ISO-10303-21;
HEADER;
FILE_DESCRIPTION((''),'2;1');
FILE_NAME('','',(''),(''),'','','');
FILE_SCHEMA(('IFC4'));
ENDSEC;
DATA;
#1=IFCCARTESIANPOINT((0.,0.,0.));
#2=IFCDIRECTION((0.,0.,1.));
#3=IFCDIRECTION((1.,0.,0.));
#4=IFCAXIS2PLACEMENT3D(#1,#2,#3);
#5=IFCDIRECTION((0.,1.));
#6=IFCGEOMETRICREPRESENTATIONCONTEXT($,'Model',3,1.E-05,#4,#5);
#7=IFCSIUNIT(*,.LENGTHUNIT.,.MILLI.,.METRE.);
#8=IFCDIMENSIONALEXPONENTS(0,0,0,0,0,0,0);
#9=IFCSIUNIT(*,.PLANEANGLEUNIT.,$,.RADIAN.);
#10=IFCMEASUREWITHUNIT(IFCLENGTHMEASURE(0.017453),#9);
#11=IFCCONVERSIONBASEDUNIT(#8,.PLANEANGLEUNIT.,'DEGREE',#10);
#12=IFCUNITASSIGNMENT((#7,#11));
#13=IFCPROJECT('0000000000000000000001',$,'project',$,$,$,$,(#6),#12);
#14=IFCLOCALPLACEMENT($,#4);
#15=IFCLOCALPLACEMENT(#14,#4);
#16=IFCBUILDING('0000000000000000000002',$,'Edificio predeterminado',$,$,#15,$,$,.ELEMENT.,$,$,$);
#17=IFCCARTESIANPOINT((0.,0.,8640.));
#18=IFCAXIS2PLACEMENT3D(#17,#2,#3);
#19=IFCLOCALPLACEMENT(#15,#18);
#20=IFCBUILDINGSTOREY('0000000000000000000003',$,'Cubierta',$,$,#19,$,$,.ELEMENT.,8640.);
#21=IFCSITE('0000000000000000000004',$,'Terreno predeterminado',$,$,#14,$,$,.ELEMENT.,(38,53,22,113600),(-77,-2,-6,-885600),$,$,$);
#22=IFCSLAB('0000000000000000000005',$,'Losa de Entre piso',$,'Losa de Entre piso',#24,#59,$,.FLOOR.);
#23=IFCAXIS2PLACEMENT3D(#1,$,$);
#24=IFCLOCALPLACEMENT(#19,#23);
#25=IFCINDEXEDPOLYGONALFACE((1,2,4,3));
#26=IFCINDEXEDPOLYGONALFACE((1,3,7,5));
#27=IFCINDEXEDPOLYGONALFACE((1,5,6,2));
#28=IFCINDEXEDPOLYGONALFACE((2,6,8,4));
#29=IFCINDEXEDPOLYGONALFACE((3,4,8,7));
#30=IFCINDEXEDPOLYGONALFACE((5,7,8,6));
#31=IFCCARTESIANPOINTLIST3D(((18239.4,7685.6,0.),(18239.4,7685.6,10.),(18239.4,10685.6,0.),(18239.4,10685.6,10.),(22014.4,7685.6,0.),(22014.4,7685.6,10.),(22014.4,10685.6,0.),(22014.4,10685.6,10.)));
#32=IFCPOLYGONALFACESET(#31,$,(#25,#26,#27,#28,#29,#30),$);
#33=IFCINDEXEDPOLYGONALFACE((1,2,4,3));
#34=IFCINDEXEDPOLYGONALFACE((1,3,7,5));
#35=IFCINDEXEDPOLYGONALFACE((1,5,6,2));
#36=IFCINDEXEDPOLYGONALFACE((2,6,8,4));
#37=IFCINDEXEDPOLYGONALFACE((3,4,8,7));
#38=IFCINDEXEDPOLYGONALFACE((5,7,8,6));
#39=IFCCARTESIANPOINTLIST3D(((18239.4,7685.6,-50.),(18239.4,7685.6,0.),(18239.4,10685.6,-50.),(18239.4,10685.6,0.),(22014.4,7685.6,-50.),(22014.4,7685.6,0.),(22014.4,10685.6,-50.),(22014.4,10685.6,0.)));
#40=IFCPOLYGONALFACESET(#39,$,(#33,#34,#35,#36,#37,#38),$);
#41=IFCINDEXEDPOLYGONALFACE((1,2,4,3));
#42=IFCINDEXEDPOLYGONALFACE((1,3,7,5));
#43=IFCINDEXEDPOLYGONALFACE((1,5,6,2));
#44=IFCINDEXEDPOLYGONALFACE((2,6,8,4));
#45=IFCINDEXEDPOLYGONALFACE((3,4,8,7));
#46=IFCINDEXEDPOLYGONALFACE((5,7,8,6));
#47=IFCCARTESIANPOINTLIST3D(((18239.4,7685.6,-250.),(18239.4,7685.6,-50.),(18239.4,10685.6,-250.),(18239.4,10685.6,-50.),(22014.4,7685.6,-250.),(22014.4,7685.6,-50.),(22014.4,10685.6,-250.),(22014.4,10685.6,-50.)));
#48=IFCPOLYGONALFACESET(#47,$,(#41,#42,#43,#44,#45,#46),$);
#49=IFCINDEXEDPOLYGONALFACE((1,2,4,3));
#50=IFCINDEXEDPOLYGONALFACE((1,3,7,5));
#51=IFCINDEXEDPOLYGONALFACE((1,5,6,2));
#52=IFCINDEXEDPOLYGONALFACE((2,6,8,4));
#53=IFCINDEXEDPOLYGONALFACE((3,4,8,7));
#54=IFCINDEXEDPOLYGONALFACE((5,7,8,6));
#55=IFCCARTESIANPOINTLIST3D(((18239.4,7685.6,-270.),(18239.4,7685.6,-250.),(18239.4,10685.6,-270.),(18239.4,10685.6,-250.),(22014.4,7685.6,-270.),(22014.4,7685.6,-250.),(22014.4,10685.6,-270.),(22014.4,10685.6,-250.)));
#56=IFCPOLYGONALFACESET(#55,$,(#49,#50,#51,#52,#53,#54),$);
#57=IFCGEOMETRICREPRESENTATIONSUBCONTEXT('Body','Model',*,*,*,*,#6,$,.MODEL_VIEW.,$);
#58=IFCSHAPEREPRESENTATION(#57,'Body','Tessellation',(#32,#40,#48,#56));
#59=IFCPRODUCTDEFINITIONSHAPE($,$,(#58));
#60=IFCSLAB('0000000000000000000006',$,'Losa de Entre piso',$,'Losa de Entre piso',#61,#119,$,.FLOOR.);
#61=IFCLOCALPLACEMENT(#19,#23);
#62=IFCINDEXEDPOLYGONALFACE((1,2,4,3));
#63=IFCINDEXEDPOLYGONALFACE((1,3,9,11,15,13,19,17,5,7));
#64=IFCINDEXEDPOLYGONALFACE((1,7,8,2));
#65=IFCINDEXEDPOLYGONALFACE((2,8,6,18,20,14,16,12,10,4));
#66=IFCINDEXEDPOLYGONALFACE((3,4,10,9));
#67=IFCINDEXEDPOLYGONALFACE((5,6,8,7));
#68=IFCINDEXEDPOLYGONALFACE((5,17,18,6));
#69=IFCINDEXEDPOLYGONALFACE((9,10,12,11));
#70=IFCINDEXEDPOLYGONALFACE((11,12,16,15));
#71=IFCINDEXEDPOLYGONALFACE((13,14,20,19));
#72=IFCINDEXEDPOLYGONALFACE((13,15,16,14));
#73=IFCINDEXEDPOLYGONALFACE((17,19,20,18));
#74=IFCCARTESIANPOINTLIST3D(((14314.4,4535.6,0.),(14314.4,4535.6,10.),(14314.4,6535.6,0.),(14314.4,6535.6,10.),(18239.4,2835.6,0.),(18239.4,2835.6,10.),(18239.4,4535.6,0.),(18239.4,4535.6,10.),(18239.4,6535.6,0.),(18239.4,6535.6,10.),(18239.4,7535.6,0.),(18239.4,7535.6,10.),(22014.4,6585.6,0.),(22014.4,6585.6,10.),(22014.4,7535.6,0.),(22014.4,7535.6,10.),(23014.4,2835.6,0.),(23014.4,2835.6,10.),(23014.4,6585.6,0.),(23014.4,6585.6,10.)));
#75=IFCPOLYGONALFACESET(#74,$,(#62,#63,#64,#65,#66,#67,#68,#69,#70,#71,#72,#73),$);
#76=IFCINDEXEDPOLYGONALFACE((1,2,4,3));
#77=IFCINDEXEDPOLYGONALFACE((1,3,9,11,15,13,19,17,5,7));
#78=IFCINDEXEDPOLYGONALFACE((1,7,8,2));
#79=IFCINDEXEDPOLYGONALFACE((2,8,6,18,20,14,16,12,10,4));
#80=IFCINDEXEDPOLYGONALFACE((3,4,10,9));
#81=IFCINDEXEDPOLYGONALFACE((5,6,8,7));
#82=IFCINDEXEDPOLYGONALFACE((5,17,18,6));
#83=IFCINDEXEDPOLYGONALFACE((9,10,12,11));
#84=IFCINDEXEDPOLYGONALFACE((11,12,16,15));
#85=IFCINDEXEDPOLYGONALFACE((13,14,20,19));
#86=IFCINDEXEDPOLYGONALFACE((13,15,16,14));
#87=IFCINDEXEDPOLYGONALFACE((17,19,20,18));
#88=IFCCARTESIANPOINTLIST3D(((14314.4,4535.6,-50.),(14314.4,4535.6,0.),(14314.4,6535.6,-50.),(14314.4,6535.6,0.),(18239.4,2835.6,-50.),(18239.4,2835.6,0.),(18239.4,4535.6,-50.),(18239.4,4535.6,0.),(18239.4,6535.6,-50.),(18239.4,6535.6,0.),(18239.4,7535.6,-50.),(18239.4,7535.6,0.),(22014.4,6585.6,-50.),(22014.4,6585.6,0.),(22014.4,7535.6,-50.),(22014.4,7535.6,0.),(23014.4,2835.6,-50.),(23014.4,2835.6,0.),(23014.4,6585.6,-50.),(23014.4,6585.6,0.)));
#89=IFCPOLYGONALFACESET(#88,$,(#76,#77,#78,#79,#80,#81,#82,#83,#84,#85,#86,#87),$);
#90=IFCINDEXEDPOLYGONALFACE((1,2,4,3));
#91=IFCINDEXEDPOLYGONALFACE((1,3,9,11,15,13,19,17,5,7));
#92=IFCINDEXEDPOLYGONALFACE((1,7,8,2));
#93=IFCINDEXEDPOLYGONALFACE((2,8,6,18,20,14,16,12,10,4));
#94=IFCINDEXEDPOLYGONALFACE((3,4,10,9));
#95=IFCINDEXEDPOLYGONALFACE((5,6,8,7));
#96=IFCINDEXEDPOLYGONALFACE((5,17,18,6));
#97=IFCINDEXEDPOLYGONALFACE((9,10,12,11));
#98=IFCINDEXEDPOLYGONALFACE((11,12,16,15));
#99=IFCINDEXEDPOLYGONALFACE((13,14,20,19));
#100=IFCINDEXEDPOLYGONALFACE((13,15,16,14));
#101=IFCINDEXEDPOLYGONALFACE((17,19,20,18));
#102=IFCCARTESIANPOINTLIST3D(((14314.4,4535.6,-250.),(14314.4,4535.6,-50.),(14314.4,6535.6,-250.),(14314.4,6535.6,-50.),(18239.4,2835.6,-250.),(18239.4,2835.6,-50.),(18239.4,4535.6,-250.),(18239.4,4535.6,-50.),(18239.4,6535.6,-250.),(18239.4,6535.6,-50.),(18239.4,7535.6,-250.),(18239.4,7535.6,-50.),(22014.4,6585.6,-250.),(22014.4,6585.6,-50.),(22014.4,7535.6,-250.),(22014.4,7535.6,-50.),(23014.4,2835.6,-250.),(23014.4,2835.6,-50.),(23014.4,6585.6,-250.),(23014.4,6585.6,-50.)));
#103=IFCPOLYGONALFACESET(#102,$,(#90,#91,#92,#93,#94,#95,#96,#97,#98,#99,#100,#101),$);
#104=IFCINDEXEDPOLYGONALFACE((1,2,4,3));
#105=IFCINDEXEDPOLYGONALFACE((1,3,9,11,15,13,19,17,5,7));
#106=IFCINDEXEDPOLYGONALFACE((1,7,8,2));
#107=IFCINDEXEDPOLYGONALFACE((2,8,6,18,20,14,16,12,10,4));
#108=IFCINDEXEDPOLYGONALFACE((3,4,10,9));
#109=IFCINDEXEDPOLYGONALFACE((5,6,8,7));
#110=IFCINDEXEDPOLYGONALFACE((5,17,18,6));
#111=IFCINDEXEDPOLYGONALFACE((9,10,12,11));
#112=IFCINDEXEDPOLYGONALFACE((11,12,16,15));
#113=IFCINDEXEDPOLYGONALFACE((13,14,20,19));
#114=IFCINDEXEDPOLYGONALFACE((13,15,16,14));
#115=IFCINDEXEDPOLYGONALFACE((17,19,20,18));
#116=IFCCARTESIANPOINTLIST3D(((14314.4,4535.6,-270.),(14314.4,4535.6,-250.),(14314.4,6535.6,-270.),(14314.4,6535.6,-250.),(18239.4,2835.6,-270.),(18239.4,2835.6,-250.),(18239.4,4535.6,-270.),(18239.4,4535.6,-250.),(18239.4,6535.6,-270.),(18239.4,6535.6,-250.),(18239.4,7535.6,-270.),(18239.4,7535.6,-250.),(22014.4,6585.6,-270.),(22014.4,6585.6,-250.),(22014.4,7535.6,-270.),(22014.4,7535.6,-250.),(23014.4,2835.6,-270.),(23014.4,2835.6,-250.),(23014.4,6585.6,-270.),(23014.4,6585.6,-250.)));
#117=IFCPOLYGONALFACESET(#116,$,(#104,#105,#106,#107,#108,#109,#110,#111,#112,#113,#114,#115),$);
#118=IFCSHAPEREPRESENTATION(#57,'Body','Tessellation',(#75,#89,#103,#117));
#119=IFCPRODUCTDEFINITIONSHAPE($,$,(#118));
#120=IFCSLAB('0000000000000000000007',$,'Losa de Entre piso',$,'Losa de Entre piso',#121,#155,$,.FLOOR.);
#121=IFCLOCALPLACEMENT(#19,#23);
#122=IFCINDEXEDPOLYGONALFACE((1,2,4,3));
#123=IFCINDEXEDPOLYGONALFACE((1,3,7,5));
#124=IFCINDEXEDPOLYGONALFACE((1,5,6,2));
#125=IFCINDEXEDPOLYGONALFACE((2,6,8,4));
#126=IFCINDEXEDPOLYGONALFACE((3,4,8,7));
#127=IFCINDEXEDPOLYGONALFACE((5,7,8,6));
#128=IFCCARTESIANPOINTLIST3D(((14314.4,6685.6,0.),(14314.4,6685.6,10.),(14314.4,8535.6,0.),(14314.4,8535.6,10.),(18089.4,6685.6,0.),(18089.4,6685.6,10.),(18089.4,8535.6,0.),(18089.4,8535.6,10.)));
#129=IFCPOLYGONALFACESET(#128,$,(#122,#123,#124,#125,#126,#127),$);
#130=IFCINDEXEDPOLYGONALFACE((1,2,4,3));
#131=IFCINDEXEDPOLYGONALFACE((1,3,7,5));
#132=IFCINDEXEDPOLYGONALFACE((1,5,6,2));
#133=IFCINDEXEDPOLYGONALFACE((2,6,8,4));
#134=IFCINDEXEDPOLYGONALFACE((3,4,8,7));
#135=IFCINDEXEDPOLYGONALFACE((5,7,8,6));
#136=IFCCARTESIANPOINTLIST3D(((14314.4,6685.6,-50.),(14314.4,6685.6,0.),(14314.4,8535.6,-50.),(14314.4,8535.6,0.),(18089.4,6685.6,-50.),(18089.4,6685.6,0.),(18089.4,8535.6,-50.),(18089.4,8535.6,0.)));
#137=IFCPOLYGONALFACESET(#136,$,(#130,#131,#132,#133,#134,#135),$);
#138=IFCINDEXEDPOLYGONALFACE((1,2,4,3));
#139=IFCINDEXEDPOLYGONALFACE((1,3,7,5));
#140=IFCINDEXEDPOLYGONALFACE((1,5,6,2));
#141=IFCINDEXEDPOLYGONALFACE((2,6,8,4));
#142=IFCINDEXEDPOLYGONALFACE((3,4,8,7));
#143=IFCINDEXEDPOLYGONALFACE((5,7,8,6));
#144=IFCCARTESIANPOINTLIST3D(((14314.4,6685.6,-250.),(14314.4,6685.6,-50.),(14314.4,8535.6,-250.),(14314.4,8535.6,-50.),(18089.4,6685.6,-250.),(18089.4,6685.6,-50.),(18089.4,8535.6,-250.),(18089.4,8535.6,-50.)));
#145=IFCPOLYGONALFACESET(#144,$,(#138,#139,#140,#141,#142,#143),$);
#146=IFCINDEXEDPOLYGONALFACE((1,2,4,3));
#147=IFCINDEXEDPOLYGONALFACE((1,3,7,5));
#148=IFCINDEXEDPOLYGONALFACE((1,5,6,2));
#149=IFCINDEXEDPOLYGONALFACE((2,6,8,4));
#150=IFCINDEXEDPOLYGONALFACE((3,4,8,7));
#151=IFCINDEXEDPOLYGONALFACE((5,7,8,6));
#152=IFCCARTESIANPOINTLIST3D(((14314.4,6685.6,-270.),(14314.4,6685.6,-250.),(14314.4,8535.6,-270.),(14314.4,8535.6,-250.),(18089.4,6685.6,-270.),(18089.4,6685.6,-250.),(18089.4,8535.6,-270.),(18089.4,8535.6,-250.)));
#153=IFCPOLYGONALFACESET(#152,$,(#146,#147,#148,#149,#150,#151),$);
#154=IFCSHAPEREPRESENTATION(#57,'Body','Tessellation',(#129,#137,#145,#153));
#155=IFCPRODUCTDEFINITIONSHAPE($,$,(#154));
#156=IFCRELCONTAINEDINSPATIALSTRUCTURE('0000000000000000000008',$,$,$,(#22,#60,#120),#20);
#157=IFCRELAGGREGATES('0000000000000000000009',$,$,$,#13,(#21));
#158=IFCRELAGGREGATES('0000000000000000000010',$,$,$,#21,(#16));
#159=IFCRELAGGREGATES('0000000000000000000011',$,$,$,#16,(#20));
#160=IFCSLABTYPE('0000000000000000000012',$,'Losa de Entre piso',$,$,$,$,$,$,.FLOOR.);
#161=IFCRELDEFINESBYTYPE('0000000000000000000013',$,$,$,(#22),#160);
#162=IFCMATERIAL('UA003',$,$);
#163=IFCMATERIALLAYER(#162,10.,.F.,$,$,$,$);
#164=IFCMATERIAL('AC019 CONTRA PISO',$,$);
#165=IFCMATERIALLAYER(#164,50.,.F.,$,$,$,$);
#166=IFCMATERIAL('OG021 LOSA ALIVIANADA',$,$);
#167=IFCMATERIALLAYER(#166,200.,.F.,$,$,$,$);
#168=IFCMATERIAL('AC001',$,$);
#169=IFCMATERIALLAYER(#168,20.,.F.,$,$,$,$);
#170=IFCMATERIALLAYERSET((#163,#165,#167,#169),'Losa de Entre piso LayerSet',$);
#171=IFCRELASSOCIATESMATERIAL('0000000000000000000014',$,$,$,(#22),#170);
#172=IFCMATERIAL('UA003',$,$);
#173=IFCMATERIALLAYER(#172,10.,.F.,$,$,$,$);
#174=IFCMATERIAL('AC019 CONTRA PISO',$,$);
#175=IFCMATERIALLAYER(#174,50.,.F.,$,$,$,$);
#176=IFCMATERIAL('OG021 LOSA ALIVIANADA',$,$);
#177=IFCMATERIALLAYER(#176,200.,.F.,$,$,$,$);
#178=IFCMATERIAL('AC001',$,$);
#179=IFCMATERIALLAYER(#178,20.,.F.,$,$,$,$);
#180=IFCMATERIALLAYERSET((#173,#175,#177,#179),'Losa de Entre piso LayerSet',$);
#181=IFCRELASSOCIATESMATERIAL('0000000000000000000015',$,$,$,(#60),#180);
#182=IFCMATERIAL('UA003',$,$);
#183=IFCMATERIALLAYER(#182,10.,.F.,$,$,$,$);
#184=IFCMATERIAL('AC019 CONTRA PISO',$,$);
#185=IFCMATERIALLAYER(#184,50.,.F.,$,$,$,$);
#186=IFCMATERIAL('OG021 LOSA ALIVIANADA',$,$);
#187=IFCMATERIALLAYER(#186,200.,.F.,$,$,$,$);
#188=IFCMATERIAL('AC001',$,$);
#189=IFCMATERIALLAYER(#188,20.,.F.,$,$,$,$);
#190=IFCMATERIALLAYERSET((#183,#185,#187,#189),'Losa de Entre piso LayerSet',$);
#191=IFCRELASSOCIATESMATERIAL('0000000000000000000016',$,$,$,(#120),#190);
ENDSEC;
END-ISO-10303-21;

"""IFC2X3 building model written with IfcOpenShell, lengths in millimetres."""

from ifc_helpers import new_model, entity, si_unit, converted_unit, direction, frame, origin_with_axes, place, context, subcontext, project, spatial, polyline, outline, extrude, material, layer, layer_set, layer_usage, type_object, element, save


model = new_model("IFC2X3")

# Units and contexts
model_context = context("Model", 3, precision=1e-05, world=origin_with_axes(), true_north=direction((0.0, 1.0)))
body_context = subcontext(model_context, "Body", "Model", "MODEL_VIEW")
ifc_project = project(units=[si_unit("LENGTHUNIT", "METRE", prefix="MILLI"), converted_unit("PLANEANGLEUNIT", "DEGREE", entity("IfcLengthMeasure", 0.017453), si_unit("PLANEANGLEUNIT", "RADIAN"), dimensions=[0, 0, 0, 0, 0, 0, 0])], contexts=[model_context])

# Site, building, storey
site_placement = place(None, origin_with_axes())
site = spatial("IfcSite", under=ifc_project, at=site_placement, Name="Terreno predeterminado", CompositionType="ELEMENT", RefLatitude=(38, 53, 22, 113600), RefLongitude=(-77, -2, -6, -885600))
building_placement = place(site_placement, origin_with_axes())
building = spatial("IfcBuilding", under=site, at=building_placement, Name="Edificio predeterminado", CompositionType="ELEMENT")
storey_placement = place(building_placement, frame((0.0, 0.0, 8640.0), z_axis=(0.0, 0.0, 1.0), x_axis=(1.0, 0.0, 0.0)))
storey = spatial("IfcBuildingStorey", under=building, at=storey_placement, Name="Cubierta", CompositionType="ELEMENT", Elevation=8640.0)

# Slabs
ifc_material_1 = material(Name="UA003")
ifc_layer_1 = layer(ifc_material_1, 10.0, ventilated=False)
ifc_material_2 = material(Name="AC019 CONTRA PISO")
ifc_layer_2 = layer(ifc_material_2, 50.0, ventilated=False)
ifc_material_3 = material(Name="OG021 LOSA ALIVIANADA")
ifc_layer_3 = layer(ifc_material_3, 200.0, ventilated=False)
ifc_material_4 = material(Name="AC001")
ifc_layer_4 = layer(ifc_material_4, 20.0, ventilated=False)
ifc_layer_set_1 = layer_set([ifc_layer_1, ifc_layer_2, ifc_layer_3, ifc_layer_4], Name="Losa de Entre piso LayerSet")
ifc_layer_usage_1 = layer_usage(ifc_layer_set_1, "AXIS3", "NEGATIVE", 0.0)
slab_type = type_object("IfcSlabType", Name="Losa de Entre piso", PredefinedType="FLOOR")
slab_1_placement = place(storey_placement, frame((0.0, 0.0, -8640.0), z_axis=(0.0, 0.0, 1.0), x_axis=(1.0, 0.0, 0.0)))
element("IfcSlab", 1, at=slab_1_placement, inside=storey, type_object=slab_type, material=ifc_layer_usage_1, Name="Losa de Entre piso", ObjectType="Losa de Entre piso", PredefinedType="FLOOR", context=body_context, shape_type="SweptSolid", body=[
    extrude(outline(polyline([(0.0, 3000.0), (3775.0, 3000.0), (3775.0, 0.0), (0.0, 0.0), (0.0, 3000.0)])), frame((22014.4, 7685.6, 8640.0), z_axis=(0.0, 0.0, -1.0), x_axis=(-1.0, 0.0, 0.0)), (0.0, 0.0, -1.0), 10.0),
    extrude(outline(polyline([(0.0, 3000.0), (3775.0, 3000.0), (3775.0, 0.0), (0.0, 0.0), (0.0, 3000.0)])), frame((22014.4, 7685.6, 8590.0), z_axis=(0.0, 0.0, -1.0), x_axis=(-1.0, 0.0, 0.0)), (0.0, 0.0, -1.0), 50.0),
    extrude(outline(polyline([(0.0, 3000.0), (3775.0, 3000.0), (3775.0, 0.0), (0.0, 0.0), (0.0, 3000.0)])), frame((22014.4, 7685.6, 8390.0), z_axis=(0.0, 0.0, -1.0), x_axis=(-1.0, 0.0, 0.0)), (0.0, 0.0, -1.0), 200.0),
    extrude(outline(polyline([(0.0, 3000.0), (3775.0, 3000.0), (3775.0, 0.0), (0.0, 0.0), (0.0, 3000.0)])), frame((22014.4, 7685.6, 8370.0), z_axis=(0.0, 0.0, -1.0), x_axis=(-1.0, 0.0, 0.0)), (0.0, 0.0, -1.0), 20.0),
])
ifc_material_5 = material(Name="UA003")
ifc_layer_5 = layer(ifc_material_5, 10.0, ventilated=False)
ifc_material_6 = material(Name="AC019 CONTRA PISO")
ifc_layer_6 = layer(ifc_material_6, 50.0, ventilated=False)
ifc_material_7 = material(Name="OG021 LOSA ALIVIANADA")
ifc_layer_7 = layer(ifc_material_7, 200.0, ventilated=False)
ifc_material_8 = material(Name="AC001")
ifc_layer_8 = layer(ifc_material_8, 20.0, ventilated=False)
ifc_layer_set_2 = layer_set([ifc_layer_5, ifc_layer_6, ifc_layer_7, ifc_layer_8], Name="Losa de Entre piso LayerSet")
ifc_layer_usage_2 = layer_usage(ifc_layer_set_2, "AXIS3", "NEGATIVE", 0.0)
slab_2_placement = place(storey_placement, frame((0.0, 0.0, -8640.0), z_axis=(0.0, 0.0, 1.0), x_axis=(1.0, 0.0, 0.0)))
element("IfcSlab", 2, at=slab_2_placement, inside=storey, material=ifc_layer_usage_2, Name="Losa de Entre piso", ObjectType="Losa de Entre piso", PredefinedType="FLOOR", context=body_context, shape_type="SweptSolid", body=[
    extrude(outline(polyline([(0.0, 1000.0), (-3925.0, 1000.0), (-3925.0, 3000.0), (0.0, 3000.0), (0.0, 4700.0), (4775.0, 4700.0), (4775.0, 950.0), (3775.0, 950.0), (3775.0, 0.0), (0.0, 0.0), (0.0, 1000.0)])), frame((18239.4, 7535.6, 8640.0), z_axis=(0.0, 0.0, -1.0), x_axis=(1.0, 0.0, 0.0)), (0.0, 0.0, -1.0), 10.0),
    extrude(outline(polyline([(0.0, 1000.0), (-3925.0, 1000.0), (-3925.0, 3000.0), (0.0, 3000.0), (0.0, 4700.0), (4775.0, 4700.0), (4775.0, 950.0), (3775.0, 950.0), (3775.0, 0.0), (0.0, 0.0), (0.0, 1000.0)])), frame((18239.4, 7535.6, 8590.0), z_axis=(0.0, 0.0, -1.0), x_axis=(1.0, 0.0, 0.0)), (0.0, 0.0, -1.0), 50.0),
    extrude(outline(polyline([(0.0, 1000.0), (-3925.0, 1000.0), (-3925.0, 3000.0), (0.0, 3000.0), (0.0, 4700.0), (4775.0, 4700.0), (4775.0, 950.0), (3775.0, 950.0), (3775.0, 0.0), (0.0, 0.0), (0.0, 1000.0)])), frame((18239.4, 7535.6, 8390.0), z_axis=(0.0, 0.0, -1.0), x_axis=(1.0, 0.0, 0.0)), (0.0, 0.0, -1.0), 200.0),
    extrude(outline(polyline([(0.0, 1000.0), (-3925.0, 1000.0), (-3925.0, 3000.0), (0.0, 3000.0), (0.0, 4700.0), (4775.0, 4700.0), (4775.0, 950.0), (3775.0, 950.0), (3775.0, 0.0), (0.0, 0.0), (0.0, 1000.0)])), frame((18239.4, 7535.6, 8370.0), z_axis=(0.0, 0.0, -1.0), x_axis=(1.0, 0.0, 0.0)), (0.0, 0.0, -1.0), 20.0),
])
ifc_material_9 = material(Name="UA003")
ifc_layer_9 = layer(ifc_material_9, 10.0, ventilated=False)
ifc_material_10 = material(Name="AC019 CONTRA PISO")
ifc_layer_10 = layer(ifc_material_10, 50.0, ventilated=False)
ifc_material_11 = material(Name="OG021 LOSA ALIVIANADA")
ifc_layer_11 = layer(ifc_material_11, 200.0, ventilated=False)
ifc_material_12 = material(Name="AC001")
ifc_layer_12 = layer(ifc_material_12, 20.0, ventilated=False)
ifc_layer_set_3 = layer_set([ifc_layer_9, ifc_layer_10, ifc_layer_11, ifc_layer_12], Name="Losa de Entre piso LayerSet")
ifc_layer_usage_3 = layer_usage(ifc_layer_set_3, "AXIS3", "NEGATIVE", 0.0)
slab_3_placement = place(storey_placement, frame((0.0, 0.0, -8640.0), z_axis=(0.0, 0.0, 1.0), x_axis=(1.0, 0.0, 0.0)))
element("IfcSlab", 3, at=slab_3_placement, inside=storey, material=ifc_layer_usage_3, Name="Losa de Entre piso", ObjectType="Losa de Entre piso", PredefinedType="FLOOR", context=body_context, shape_type="SweptSolid", body=[
    extrude(outline(polyline([(0.0, 1850.0), (3775.0, 1850.0), (3775.0, 0.0), (0.0, 0.0), (0.0, 1850.0)])), frame((18089.4, 6685.6, 8640.0), z_axis=(0.0, 0.0, -1.0), x_axis=(-1.0, 0.0, 0.0)), (0.0, 0.0, -1.0), 10.0),
    extrude(outline(polyline([(0.0, 1850.0), (3775.0, 1850.0), (3775.0, 0.0), (0.0, 0.0), (0.0, 1850.0)])), frame((18089.4, 6685.6, 8590.0), z_axis=(0.0, 0.0, -1.0), x_axis=(-1.0, 0.0, 0.0)), (0.0, 0.0, -1.0), 50.0),
    extrude(outline(polyline([(0.0, 1850.0), (3775.0, 1850.0), (3775.0, 0.0), (0.0, 0.0), (0.0, 1850.0)])), frame((18089.4, 6685.6, 8390.0), z_axis=(0.0, 0.0, -1.0), x_axis=(-1.0, 0.0, 0.0)), (0.0, 0.0, -1.0), 200.0),
    extrude(outline(polyline([(0.0, 1850.0), (3775.0, 1850.0), (3775.0, 0.0), (0.0, 0.0), (0.0, 1850.0)])), frame((18089.4, 6685.6, 8370.0), z_axis=(0.0, 0.0, -1.0), x_axis=(-1.0, 0.0, 0.0)), (0.0, 0.0, -1.0), 20.0),
])

save(model, "model.ifc")
